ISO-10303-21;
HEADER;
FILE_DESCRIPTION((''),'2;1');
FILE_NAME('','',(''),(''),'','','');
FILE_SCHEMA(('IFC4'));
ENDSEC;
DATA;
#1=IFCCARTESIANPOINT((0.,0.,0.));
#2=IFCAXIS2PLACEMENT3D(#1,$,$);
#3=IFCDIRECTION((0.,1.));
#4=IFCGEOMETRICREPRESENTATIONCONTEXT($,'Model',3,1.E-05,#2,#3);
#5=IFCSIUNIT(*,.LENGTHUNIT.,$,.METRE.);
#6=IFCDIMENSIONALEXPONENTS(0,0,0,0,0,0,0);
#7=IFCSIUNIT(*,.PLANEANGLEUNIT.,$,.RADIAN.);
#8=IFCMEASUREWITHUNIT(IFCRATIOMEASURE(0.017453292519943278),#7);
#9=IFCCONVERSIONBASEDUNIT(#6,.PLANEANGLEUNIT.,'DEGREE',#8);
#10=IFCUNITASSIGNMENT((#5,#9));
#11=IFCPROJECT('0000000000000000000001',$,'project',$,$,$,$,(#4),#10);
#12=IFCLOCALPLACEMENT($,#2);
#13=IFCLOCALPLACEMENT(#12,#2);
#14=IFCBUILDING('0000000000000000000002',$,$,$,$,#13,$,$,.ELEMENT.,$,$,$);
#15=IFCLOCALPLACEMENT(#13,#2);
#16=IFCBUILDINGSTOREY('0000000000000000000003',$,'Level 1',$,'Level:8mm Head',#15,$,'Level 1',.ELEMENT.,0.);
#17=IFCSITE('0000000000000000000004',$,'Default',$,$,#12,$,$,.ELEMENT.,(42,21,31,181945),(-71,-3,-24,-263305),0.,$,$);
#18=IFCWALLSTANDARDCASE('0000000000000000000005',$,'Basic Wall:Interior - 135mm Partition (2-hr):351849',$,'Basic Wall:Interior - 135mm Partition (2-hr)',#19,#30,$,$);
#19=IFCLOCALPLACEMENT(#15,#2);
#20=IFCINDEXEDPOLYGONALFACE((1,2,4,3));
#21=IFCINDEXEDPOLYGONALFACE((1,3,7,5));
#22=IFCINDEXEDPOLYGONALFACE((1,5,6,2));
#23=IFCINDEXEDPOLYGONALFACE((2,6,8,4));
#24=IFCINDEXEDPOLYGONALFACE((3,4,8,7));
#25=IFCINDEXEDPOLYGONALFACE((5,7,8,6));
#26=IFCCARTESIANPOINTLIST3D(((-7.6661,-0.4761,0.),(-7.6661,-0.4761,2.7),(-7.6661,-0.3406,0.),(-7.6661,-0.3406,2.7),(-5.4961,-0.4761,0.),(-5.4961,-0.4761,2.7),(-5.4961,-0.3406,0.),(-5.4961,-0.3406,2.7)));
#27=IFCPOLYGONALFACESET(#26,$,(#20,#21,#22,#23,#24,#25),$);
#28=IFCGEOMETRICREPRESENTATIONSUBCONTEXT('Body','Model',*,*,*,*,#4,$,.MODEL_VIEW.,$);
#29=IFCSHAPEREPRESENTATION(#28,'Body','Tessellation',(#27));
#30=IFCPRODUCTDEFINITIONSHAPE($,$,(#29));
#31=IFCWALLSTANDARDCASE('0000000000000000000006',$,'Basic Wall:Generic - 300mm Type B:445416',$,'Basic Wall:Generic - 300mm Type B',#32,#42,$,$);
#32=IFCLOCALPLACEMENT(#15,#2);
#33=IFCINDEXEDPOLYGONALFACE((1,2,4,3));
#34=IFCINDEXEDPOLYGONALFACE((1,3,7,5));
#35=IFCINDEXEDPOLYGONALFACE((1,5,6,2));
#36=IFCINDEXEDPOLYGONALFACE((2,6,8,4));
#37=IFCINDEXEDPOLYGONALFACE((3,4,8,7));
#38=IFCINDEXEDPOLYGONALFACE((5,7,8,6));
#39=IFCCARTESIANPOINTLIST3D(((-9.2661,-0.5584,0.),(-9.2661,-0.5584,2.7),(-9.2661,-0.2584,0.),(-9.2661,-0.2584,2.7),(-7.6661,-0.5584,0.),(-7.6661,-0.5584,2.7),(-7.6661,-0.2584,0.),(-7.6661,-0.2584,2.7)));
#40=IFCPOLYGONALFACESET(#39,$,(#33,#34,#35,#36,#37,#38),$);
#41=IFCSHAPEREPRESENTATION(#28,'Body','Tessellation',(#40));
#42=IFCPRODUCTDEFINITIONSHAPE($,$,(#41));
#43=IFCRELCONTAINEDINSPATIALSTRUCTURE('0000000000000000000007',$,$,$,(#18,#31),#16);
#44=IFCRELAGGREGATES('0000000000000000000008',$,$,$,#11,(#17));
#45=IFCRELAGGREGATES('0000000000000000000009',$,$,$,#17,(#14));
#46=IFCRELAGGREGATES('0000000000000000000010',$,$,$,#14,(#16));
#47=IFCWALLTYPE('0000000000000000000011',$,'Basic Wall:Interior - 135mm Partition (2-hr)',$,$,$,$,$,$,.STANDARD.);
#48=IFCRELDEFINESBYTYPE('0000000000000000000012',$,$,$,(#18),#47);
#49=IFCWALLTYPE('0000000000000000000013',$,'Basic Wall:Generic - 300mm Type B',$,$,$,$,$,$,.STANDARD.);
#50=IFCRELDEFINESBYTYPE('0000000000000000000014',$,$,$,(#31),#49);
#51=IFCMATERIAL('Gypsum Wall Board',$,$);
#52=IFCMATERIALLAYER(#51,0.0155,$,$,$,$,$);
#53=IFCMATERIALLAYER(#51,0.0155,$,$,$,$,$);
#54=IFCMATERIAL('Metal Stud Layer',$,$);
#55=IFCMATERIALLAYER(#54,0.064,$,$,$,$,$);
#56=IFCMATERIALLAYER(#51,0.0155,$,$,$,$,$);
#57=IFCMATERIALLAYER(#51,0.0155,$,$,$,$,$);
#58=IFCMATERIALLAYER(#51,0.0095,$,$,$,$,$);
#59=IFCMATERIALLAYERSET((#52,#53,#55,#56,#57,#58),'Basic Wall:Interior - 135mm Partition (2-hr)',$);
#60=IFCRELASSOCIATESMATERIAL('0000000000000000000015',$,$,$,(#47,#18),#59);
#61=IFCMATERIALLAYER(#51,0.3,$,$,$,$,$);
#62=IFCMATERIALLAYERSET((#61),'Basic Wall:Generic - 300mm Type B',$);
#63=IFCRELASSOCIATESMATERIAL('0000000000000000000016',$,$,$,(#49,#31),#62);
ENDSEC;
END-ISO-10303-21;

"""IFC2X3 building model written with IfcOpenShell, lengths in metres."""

from ifc_helpers import new_model, entity, si_unit, converted_unit, direction, frame, frame_2d, origin, place, context, subcontext, project, spatial, rectangle, extrude, material, layer, layer_set, layer_usage, type_object, element, save


model = new_model("IFC2X3")

# Units and contexts
model_context = context("Model", 3, precision=1e-05, world=origin(), true_north=direction((0.0, 1.0)))
body_context = subcontext(model_context, "Body", "Model", "MODEL_VIEW")
ifc_project = project(units=[si_unit("LENGTHUNIT", "METRE"), converted_unit("PLANEANGLEUNIT", "DEGREE", entity("IfcRatioMeasure", 0.017453292519943278), si_unit("PLANEANGLEUNIT", "RADIAN"), dimensions=[0, 0, 0, 0, 0, 0, 0])], contexts=[model_context])

# Site, building, storey
site_placement = place(None, origin())
site = spatial("IfcSite", under=ifc_project, at=site_placement, Name="Default", CompositionType="ELEMENT", RefLatitude=(42, 21, 31, 181945), RefLongitude=(-71, -3, -24, -263305), RefElevation=0.0)
building_placement = place(site_placement, origin())
building = spatial("IfcBuilding", under=site, at=building_placement, CompositionType="ELEMENT")
storey_placement = place(building_placement, origin())
storey = spatial("IfcBuildingStorey", under=building, at=storey_placement, Name="Level 1", ObjectType="Level:8mm Head", LongName="Level 1", CompositionType="ELEMENT", Elevation=0.0)

# Walls
ifc_material_1 = material(Name="Gypsum Wall Board")
ifc_layer_1 = layer(ifc_material_1, 0.0155)
ifc_layer_2 = layer(ifc_material_1, 0.0155)
ifc_material_2 = material(Name="Metal Stud Layer")
ifc_layer_3 = layer(ifc_material_2, 0.064)
ifc_layer_4 = layer(ifc_material_1, 0.0155)
ifc_layer_5 = layer(ifc_material_1, 0.0155)
ifc_layer_6 = layer(ifc_material_1, 0.0095)
ifc_layer_set_1 = layer_set([ifc_layer_1, ifc_layer_2, ifc_layer_3, ifc_layer_4, ifc_layer_5, ifc_layer_6], Name="Basic Wall:Interior - 135mm Partition (2-hr)")
ifc_layer_usage_1 = layer_usage(ifc_layer_set_1, "AXIS2", "NEGATIVE", 0.0677)
wall_type_1 = type_object("IfcWallType", Name="Basic Wall:Interior - 135mm Partition (2-hr)", PredefinedType="STANDARD", material=ifc_layer_set_1)
wall_1_placement = place(storey_placement, frame((-5.4961, -0.4084, 0.0), z_axis=(0.0, 0.0, 1.0), x_axis=(-1.0, 0.0, 0.0)))
element("IfcWallStandardCase", 1, at=wall_1_placement, inside=storey, type_object=wall_type_1, material=ifc_layer_usage_1, Name="Basic Wall:Interior - 135mm Partition (2-hr):351849", ObjectType="Basic Wall:Interior - 135mm Partition (2-hr)", context=body_context, shape_type="SweptSolid", body=[
    extrude(rectangle(XDim=2.17, YDim=0.1355, at=frame_2d((1.085, 0.0), x_axis=(-1.0, 0.0))), origin(), (0.0, 0.0, 1.0), 2.7),
])
ifc_layer_7 = layer(ifc_material_1, 0.3)
ifc_layer_set_2 = layer_set([ifc_layer_7], Name="Basic Wall:Generic - 300mm Type B")
ifc_layer_usage_2 = layer_usage(ifc_layer_set_2, "AXIS2", "NEGATIVE", 0.15)
wall_type_2 = type_object("IfcWallType", Name="Basic Wall:Generic - 300mm Type B", PredefinedType="STANDARD", material=ifc_layer_set_2)
wall_2_placement = place(storey_placement, frame((-7.6661, -0.4084, 0.0), z_axis=(0.0, 0.0, 1.0), x_axis=(-1.0, 0.0, 0.0)))
element("IfcWallStandardCase", 2, at=wall_2_placement, inside=storey, type_object=wall_type_2, material=ifc_layer_usage_2, Name="Basic Wall:Generic - 300mm Type B:445416", ObjectType="Basic Wall:Generic - 300mm Type B", context=body_context, shape_type="SweptSolid", body=[
    extrude(rectangle(XDim=1.6, YDim=0.3, at=frame_2d((0.8, 0.0), x_axis=(-1.0, 0.0))), origin(), (0.0, 0.0, 1.0), 2.7),
])

save(model, "model.ifc")
